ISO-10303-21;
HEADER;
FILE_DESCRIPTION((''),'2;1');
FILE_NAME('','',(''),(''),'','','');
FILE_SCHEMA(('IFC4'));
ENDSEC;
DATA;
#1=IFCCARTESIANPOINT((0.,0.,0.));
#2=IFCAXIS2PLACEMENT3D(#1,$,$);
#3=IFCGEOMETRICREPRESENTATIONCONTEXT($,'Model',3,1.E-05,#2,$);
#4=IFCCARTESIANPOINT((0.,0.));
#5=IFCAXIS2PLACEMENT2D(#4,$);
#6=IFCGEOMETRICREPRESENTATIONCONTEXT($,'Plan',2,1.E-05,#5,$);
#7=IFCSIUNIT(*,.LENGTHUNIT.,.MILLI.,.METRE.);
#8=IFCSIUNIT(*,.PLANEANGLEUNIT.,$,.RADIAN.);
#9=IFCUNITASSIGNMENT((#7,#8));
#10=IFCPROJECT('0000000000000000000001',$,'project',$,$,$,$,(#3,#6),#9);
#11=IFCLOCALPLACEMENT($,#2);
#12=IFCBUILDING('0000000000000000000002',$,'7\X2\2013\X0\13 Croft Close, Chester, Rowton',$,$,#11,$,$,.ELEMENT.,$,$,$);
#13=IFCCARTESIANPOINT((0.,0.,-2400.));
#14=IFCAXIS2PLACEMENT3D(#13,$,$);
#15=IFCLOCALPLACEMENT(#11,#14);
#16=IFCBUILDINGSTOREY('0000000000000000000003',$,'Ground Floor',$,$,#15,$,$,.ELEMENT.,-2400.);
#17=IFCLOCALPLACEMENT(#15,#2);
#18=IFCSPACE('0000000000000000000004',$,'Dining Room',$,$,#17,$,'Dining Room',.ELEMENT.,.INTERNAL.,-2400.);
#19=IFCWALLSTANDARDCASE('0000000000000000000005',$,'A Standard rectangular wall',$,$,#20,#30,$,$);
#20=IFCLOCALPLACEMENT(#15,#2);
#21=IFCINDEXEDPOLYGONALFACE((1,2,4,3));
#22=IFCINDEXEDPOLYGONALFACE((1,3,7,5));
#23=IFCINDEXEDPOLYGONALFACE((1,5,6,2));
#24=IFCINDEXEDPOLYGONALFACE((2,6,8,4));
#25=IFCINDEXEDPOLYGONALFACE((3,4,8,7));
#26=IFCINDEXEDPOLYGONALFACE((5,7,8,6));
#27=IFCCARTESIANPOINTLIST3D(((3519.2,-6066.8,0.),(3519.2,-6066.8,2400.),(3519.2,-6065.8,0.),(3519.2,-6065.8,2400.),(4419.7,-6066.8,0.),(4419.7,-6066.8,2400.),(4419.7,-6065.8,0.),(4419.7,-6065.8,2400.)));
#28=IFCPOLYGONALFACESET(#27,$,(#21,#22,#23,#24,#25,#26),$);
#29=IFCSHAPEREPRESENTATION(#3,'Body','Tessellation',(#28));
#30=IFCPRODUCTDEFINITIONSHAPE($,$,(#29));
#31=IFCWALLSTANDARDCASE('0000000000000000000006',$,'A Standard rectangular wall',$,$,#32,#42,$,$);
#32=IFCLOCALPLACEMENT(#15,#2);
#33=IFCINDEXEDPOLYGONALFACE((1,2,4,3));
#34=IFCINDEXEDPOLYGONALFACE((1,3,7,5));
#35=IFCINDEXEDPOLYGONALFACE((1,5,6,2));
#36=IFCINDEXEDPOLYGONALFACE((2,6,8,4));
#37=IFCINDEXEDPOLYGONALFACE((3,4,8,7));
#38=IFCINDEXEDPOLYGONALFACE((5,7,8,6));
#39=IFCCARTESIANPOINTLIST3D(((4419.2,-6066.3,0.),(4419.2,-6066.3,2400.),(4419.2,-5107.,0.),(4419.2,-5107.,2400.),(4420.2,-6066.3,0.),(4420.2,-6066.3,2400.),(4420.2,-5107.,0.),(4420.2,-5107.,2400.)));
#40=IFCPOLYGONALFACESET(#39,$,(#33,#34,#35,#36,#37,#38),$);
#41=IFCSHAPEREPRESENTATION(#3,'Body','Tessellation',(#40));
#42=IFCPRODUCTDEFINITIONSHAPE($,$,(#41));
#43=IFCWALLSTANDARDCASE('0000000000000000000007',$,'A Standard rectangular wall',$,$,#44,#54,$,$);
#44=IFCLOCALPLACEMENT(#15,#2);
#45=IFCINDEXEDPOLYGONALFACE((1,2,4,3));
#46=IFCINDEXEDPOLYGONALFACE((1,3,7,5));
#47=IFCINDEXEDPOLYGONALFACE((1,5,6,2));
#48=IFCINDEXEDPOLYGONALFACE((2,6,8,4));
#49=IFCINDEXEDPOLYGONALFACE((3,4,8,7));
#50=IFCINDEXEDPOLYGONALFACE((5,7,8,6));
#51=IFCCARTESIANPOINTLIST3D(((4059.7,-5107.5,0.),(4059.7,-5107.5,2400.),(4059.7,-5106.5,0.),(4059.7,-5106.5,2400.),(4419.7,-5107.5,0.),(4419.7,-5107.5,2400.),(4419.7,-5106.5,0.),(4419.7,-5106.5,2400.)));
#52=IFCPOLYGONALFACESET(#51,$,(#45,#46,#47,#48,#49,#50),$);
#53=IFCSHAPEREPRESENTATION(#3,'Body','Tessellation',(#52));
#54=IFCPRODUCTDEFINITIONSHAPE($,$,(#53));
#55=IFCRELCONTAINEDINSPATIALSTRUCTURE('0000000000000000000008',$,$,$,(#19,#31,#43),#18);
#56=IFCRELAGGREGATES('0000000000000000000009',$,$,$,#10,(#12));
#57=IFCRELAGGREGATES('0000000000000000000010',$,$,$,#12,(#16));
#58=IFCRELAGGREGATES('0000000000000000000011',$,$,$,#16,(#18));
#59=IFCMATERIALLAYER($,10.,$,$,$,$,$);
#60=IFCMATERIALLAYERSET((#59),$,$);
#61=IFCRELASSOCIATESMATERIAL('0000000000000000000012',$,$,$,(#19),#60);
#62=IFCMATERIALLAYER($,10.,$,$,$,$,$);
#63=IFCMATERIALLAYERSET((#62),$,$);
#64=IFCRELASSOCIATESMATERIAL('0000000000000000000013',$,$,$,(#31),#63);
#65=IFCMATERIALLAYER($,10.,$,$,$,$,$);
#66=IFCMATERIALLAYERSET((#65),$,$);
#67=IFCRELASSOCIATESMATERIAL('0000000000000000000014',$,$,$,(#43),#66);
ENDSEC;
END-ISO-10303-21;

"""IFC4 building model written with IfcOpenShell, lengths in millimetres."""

from ifc_helpers import new_model, si_unit, frame, origin, origin_2d, place, context, project, spatial, rectangle, extrude, layer, layer_set, layer_usage, element, save


model = new_model("IFC4")

# Units and contexts
model_context = context("Model", 3, precision=1e-05, world=origin())
plan_context = context("Plan", 2, precision=1e-05, world=origin_2d())
ifc_project = project(units=[si_unit("LENGTHUNIT", "METRE", prefix="MILLI"), si_unit("PLANEANGLEUNIT", "RADIAN")], contexts=[model_context, plan_context])

# Building, storey
building_placement = place(None, origin())
building = spatial("IfcBuilding", under=ifc_project, at=building_placement, Name="7–13 Croft Close, Chester, Rowton", CompositionType="ELEMENT")
storey_placement = place(building_placement, frame((0.0, 0.0, -2400.0)))
storey = spatial("IfcBuildingStorey", under=building, at=storey_placement, Name="Ground Floor", CompositionType="ELEMENT", Elevation=-2400.0)

# Shared definitions
space_1_placement = place(storey_placement, origin())
space_1 = spatial("IfcSpace", under=storey, at=space_1_placement, Name="Dining Room", LongName="Dining Room", CompositionType="ELEMENT", PredefinedType="INTERNAL", ElevationWithFlooring=-2400.0)

# Walls
ifc_layer_1 = layer(None, 10.0)
ifc_layer_set_1 = layer_set([ifc_layer_1])
ifc_layer_usage_1 = layer_usage(ifc_layer_set_1, "AXIS2", "NEGATIVE", 150.0)
wall_1_placement = place(storey_placement, origin())
element("IfcWallStandardCase", 1, at=wall_1_placement, inside=space_1, material=ifc_layer_usage_1, Name="A Standard rectangular wall", context=model_context, shape_type="SweptSolid", body=[
    extrude(rectangle(XDim=1.0, YDim=900.5, at=origin_2d()), frame((3969.5, -6066.3, 0.0), x_axis=(0.0, 1.0, 0.0)), (0.0, 0.0, 1.0), 2400.0),
])
ifc_layer_2 = layer(None, 10.0)
ifc_layer_set_2 = layer_set([ifc_layer_2])
ifc_layer_usage_2 = layer_usage(ifc_layer_set_2, "AXIS2", "NEGATIVE", 150.0)
wall_2_placement = place(storey_placement, origin())
element("IfcWallStandardCase", 2, at=wall_2_placement, inside=space_1, material=ifc_layer_usage_2, Name="A Standard rectangular wall", context=model_context, shape_type="SweptSolid", body=[
    extrude(rectangle(XDim=1.0, YDim=959.3, at=origin_2d()), frame((4419.7, -5586.6, 0.0), x_axis=(-1.0, 0.0, 0.0)), (0.0, 0.0, 1.0), 2400.0),
])
ifc_layer_3 = layer(None, 10.0)
ifc_layer_set_3 = layer_set([ifc_layer_3])
ifc_layer_usage_3 = layer_usage(ifc_layer_set_3, "AXIS2", "NEGATIVE", 150.0)
wall_3_placement = place(storey_placement, origin())
element("IfcWallStandardCase", 3, at=wall_3_placement, inside=space_1, material=ifc_layer_usage_3, Name="A Standard rectangular wall", context=model_context, shape_type="SweptSolid", body=[
    extrude(rectangle(XDim=1.0, YDim=360.0, at=origin_2d()), frame((4239.7, -5107.0, 0.0), x_axis=(0.0, -1.0, 0.0)), (0.0, 0.0, 1.0), 2400.0),
])

save(model, "model.ifc")
